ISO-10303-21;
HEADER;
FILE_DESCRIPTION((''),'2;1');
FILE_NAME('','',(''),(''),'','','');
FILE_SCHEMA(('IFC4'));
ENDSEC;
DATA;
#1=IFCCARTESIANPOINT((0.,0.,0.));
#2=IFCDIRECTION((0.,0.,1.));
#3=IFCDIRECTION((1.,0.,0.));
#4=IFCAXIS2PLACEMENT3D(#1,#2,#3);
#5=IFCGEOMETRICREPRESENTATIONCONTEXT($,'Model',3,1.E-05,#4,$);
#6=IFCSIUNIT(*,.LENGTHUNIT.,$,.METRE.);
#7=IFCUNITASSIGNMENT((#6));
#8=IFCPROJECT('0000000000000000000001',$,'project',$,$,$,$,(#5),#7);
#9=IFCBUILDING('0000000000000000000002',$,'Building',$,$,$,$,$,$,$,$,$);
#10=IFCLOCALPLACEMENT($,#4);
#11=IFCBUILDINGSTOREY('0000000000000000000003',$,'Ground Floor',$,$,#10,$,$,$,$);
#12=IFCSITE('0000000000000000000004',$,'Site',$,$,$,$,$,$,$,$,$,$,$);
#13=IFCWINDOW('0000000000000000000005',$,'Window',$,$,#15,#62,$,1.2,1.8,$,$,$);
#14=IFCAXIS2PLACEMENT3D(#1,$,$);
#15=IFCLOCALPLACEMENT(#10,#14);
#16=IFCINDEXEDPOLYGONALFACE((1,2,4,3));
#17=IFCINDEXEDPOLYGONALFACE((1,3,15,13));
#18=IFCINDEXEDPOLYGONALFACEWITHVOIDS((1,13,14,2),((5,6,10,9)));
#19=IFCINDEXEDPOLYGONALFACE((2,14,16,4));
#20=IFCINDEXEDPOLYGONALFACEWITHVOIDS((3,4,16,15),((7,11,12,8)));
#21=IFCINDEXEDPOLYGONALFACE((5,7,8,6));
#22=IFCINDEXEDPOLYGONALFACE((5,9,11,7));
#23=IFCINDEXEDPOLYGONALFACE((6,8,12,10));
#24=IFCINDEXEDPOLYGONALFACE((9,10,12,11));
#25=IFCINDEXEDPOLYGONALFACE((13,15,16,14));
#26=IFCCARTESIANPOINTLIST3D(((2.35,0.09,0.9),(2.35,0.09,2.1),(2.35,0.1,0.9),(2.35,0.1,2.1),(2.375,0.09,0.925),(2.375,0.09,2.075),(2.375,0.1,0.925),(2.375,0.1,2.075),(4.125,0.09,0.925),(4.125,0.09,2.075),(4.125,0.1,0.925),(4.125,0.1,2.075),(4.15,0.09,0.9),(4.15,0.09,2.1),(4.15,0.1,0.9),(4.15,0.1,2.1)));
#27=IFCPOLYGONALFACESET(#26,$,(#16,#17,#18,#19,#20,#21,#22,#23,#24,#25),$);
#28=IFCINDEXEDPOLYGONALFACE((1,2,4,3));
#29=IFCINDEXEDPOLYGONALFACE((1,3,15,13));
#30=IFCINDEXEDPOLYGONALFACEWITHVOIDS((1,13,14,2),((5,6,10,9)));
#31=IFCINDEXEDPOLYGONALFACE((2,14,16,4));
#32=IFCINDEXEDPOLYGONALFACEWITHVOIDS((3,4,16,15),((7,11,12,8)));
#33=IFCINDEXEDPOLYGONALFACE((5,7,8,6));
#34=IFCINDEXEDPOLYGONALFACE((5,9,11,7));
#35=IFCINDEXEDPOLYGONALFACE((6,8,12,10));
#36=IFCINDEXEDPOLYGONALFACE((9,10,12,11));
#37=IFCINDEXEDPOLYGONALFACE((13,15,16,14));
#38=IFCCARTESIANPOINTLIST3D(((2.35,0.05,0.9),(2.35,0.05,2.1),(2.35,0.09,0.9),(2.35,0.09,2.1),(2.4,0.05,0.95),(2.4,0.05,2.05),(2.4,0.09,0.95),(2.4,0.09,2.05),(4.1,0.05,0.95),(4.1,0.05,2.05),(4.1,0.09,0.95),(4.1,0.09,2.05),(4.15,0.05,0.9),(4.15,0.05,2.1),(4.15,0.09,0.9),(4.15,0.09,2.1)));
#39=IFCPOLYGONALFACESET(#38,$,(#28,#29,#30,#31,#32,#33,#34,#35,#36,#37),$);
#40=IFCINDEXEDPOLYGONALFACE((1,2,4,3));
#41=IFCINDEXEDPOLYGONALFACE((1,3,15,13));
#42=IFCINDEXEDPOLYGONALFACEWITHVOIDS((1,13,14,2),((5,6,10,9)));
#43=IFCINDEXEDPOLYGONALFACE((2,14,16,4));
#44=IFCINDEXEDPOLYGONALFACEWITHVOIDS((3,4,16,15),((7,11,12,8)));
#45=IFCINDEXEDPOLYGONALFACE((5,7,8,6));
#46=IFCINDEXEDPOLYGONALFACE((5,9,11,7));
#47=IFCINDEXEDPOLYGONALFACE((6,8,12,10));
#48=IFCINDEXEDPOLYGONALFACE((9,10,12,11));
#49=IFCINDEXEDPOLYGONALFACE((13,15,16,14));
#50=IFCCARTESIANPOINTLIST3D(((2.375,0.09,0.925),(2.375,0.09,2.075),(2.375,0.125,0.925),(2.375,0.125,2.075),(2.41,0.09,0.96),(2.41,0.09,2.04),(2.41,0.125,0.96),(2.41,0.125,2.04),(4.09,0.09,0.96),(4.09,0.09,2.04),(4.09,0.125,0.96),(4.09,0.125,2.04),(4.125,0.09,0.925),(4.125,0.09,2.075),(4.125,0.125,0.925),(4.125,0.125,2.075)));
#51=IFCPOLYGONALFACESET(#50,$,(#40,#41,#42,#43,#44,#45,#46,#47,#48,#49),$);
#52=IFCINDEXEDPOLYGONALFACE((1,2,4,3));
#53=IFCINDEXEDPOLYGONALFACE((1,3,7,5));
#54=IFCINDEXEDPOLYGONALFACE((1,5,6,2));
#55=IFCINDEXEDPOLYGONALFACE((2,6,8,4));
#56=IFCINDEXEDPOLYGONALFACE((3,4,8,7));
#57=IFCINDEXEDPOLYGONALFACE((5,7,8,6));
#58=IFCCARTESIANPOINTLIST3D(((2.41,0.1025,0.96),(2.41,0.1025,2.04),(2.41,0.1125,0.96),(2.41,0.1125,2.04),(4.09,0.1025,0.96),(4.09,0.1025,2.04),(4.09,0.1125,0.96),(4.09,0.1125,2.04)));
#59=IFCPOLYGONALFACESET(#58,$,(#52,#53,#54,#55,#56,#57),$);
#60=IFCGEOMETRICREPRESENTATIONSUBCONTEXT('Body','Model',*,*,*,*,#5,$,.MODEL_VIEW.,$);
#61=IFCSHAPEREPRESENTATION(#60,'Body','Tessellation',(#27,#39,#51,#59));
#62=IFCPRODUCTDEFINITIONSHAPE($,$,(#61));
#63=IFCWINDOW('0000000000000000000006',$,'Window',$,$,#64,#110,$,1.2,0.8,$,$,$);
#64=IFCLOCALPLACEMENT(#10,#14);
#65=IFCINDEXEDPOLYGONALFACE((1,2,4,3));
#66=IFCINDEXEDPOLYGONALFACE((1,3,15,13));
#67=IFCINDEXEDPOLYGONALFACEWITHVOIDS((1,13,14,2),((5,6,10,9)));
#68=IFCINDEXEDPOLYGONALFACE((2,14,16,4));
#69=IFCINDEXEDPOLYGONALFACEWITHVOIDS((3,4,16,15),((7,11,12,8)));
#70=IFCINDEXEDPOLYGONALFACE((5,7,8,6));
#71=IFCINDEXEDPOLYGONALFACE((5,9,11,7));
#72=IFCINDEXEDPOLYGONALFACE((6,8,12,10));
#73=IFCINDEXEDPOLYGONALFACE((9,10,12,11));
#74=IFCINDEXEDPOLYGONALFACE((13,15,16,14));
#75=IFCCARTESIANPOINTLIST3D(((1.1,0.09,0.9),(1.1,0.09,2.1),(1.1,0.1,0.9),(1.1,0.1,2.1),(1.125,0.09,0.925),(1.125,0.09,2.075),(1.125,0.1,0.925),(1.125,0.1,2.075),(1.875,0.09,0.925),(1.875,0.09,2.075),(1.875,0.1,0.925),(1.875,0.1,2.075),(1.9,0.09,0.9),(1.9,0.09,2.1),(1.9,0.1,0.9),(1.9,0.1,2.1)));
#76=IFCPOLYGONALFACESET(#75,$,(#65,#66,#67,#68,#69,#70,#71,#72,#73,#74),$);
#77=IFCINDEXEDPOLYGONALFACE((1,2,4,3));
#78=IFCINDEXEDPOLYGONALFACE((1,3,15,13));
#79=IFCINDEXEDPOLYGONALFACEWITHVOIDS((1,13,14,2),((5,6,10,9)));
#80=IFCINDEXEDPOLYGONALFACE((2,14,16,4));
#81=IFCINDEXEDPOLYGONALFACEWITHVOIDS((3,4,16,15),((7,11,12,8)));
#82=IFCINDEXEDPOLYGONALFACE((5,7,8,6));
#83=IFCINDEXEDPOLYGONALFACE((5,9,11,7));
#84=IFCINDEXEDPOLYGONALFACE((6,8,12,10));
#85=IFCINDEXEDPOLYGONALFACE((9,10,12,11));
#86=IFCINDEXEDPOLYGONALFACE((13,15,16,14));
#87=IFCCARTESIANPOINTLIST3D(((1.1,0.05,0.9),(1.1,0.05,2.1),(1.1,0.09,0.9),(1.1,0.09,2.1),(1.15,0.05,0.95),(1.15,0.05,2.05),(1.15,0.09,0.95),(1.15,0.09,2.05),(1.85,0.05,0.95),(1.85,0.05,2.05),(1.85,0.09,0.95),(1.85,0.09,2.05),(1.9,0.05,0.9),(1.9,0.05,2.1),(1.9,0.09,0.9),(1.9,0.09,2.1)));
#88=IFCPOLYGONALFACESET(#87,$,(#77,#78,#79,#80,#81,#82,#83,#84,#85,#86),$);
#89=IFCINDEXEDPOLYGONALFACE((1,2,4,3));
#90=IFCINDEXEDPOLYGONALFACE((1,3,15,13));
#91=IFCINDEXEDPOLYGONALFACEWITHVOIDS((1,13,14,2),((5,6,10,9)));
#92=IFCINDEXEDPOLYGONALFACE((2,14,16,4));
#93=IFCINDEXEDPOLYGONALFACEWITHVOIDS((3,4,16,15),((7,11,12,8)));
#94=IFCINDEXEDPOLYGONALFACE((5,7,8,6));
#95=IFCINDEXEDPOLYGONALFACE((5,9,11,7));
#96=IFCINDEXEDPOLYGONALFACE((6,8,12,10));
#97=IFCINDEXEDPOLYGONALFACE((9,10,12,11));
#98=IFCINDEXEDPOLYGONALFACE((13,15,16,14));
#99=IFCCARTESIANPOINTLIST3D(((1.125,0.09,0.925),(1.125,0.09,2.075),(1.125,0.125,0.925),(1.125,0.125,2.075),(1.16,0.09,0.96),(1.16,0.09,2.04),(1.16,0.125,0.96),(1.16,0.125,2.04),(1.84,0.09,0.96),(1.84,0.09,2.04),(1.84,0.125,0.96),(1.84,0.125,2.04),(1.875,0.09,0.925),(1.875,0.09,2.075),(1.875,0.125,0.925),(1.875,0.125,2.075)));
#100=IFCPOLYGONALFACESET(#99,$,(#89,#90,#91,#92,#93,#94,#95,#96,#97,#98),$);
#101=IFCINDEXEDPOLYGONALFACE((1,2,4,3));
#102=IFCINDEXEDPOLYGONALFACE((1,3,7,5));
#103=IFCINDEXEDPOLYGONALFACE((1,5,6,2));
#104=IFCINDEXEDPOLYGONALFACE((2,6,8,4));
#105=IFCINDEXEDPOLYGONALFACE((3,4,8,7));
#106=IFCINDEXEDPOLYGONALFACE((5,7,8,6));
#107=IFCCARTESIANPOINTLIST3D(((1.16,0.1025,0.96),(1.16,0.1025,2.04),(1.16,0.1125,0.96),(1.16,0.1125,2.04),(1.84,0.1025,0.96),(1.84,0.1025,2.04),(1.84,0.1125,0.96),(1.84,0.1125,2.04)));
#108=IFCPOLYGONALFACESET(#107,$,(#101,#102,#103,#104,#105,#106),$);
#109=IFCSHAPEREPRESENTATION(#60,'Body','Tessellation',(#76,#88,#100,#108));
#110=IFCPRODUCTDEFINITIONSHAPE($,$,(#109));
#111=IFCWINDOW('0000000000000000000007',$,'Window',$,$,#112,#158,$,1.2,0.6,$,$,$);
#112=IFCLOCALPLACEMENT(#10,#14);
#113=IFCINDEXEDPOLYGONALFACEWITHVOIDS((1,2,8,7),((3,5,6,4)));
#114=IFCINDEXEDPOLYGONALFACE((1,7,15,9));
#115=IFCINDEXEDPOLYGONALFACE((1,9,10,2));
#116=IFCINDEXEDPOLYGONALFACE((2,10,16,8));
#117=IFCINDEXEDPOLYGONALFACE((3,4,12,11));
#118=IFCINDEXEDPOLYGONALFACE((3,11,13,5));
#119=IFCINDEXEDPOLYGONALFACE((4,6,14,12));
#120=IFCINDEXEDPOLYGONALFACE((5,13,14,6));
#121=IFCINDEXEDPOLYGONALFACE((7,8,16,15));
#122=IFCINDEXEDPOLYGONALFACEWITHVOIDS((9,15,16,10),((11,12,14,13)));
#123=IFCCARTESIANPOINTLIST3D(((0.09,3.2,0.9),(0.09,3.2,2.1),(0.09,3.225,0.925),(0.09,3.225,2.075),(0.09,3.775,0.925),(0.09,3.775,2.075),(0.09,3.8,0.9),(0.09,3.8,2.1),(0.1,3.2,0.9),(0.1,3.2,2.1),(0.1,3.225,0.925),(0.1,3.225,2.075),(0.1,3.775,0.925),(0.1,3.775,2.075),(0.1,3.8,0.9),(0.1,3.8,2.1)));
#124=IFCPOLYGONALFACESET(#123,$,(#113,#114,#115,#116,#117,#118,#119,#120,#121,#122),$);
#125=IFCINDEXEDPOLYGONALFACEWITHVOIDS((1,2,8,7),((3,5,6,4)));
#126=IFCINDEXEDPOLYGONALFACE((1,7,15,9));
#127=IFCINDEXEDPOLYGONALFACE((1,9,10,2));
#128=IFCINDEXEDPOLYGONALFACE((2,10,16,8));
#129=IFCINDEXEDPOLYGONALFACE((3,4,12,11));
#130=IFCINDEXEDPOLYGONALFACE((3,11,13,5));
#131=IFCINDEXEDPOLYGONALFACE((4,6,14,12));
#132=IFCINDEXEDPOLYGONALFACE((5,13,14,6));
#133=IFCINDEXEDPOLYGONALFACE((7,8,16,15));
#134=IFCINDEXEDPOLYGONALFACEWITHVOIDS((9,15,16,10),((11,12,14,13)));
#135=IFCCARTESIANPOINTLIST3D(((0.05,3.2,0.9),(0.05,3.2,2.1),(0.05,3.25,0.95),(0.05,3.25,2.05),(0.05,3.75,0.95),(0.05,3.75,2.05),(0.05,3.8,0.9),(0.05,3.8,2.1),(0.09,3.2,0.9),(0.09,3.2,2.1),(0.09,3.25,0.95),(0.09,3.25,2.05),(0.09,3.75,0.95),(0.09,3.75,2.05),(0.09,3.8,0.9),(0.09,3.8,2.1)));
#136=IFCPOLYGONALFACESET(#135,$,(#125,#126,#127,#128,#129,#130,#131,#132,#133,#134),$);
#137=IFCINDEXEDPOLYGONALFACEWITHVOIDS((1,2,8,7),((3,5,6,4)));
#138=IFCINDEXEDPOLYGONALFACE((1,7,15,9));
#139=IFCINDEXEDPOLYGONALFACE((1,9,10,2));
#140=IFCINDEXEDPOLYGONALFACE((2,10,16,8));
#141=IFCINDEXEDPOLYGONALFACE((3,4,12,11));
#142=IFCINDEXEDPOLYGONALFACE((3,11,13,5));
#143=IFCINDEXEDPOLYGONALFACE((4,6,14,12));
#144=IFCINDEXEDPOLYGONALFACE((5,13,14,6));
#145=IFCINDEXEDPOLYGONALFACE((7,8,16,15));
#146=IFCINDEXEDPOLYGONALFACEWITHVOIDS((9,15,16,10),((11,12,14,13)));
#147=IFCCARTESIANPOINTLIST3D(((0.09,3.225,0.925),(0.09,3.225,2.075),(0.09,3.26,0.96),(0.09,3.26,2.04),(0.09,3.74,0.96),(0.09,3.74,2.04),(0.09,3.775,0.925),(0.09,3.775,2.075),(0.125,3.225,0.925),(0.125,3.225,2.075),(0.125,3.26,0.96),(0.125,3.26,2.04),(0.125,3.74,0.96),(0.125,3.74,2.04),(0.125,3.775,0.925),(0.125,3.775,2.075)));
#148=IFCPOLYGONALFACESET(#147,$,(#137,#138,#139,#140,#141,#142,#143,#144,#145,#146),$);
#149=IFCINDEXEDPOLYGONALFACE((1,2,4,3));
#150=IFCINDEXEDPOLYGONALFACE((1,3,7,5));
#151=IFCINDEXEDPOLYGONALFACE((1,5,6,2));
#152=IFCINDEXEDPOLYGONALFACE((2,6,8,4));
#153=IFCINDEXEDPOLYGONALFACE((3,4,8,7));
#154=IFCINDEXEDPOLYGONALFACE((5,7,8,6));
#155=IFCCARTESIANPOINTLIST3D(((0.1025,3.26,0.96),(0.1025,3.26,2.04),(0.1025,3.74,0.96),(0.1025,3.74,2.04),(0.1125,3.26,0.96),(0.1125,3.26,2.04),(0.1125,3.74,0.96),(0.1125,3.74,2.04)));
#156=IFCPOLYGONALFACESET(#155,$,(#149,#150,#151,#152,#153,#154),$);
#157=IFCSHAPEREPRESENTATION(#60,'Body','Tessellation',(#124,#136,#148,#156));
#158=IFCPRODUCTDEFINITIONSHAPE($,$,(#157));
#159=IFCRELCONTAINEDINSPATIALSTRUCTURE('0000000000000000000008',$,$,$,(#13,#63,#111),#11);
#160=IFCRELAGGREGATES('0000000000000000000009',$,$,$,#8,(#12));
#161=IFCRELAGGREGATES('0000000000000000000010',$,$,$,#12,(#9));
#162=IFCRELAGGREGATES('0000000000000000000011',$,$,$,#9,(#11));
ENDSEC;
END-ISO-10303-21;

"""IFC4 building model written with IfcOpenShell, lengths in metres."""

from ifc_helpers import new_model, si_unit, frame, origin_with_axes, place, context, subcontext, project, spatial, line, indexed_curve, outline, extrude, element, save


model = new_model("IFC4")

# Units and contexts
model_context = context("Model", 3, precision=1e-05, world=origin_with_axes())
body_context = subcontext(model_context, "Body", "Model", "MODEL_VIEW")
ifc_project = project(units=[si_unit("LENGTHUNIT", "METRE")], contexts=[model_context])

# Site, building, storey
site = spatial("IfcSite", under=ifc_project, Name="Site")
building = spatial("IfcBuilding", under=site, Name="Building")
storey_placement = place(None, origin_with_axes())
storey = spatial("IfcBuildingStorey", under=building, at=storey_placement, Name="Ground Floor")

# Windows
window_1_placement = place(storey_placement, frame((2.35, 0.0, 0.9), z_axis=(0.0, 0.0, 1.0), x_axis=(1.0, 0.0, 0.0)))
element("IfcWindow", 1, at=window_1_placement, inside=storey, Name="Window", OverallHeight=1.2, OverallWidth=1.8, context=body_context, shape_type="SweptSolid", body=[
    extrude(outline(indexed_curve([(0.0, 0.0), (1.8, 0.0), (1.8, 1.2), (0.0, 1.2)], segments=[line(1, 2, 3, 4, 1)]), holes=[indexed_curve([(0.025, 0.025), (1.775, 0.025), (1.775, 1.175), (0.025, 1.175)], segments=[line(1, 2, 3, 4, 1)])]), frame((0.0, 0.09, 0.0), z_axis=(0.0, -1.0, 0.0), x_axis=(1.0, 0.0, 0.0)), (0.0, 0.0, -1.0), 0.01),
    extrude(outline(indexed_curve([(0.0, 0.0), (1.8, 0.0), (1.8, 1.2), (0.0, 1.2)], segments=[line(1, 2, 3, 4, 1)]), holes=[indexed_curve([(0.05, 0.05), (1.75, 0.05), (1.75, 1.15), (0.05, 1.15)], segments=[line(1, 2, 3, 4, 1)])]), frame((0.0, 0.05, 0.0), z_axis=(0.0, -1.0, 0.0), x_axis=(1.0, 0.0, 0.0)), (0.0, 0.0, -1.0), 0.04),
    extrude(outline(indexed_curve([(0.0, 0.0), (1.75, 0.0), (1.75, 1.15), (0.0, 1.15)], segments=[line(1, 2, 3, 4, 1)]), holes=[indexed_curve([(0.035, 0.035), (1.715, 0.035), (1.715, 1.115), (0.035, 1.115)], segments=[line(1, 2, 3, 4, 1)])]), frame((0.025, 0.09, 0.025), z_axis=(0.0, -1.0, 0.0), x_axis=(1.0, 0.0, 0.0)), (0.0, 0.0, -1.0), 0.035),
    extrude(outline(indexed_curve([(0.035, 0.035), (1.715, 0.035), (1.715, 1.115), (0.035, 1.115)], segments=[line(1, 2, 3, 4, 1)])), frame((0.025, 0.1025, 0.025), z_axis=(0.0, -1.0, 0.0), x_axis=(1.0, 0.0, 0.0)), (0.0, 0.0, -1.0), 0.01),
])
window_2_placement = place(storey_placement, frame((1.1, 0.0, 0.9), z_axis=(0.0, 0.0, 1.0), x_axis=(1.0, 0.0, 0.0)))
element("IfcWindow", 2, at=window_2_placement, inside=storey, Name="Window", OverallHeight=1.2, OverallWidth=0.8, context=body_context, shape_type="SweptSolid", body=[
    extrude(outline(indexed_curve([(0.0, 0.0), (0.8, 0.0), (0.8, 1.2), (0.0, 1.2)], segments=[line(1, 2, 3, 4, 1)]), holes=[indexed_curve([(0.025, 0.025), (0.775, 0.025), (0.775, 1.175), (0.025, 1.175)], segments=[line(1, 2, 3, 4, 1)])]), frame((0.0, 0.09, 0.0), z_axis=(0.0, -1.0, 0.0), x_axis=(1.0, 0.0, 0.0)), (0.0, 0.0, -1.0), 0.01),
    extrude(outline(indexed_curve([(0.0, 0.0), (0.8, 0.0), (0.8, 1.2), (0.0, 1.2)], segments=[line(1, 2, 3, 4, 1)]), holes=[indexed_curve([(0.05, 0.05), (0.75, 0.05), (0.75, 1.15), (0.05, 1.15)], segments=[line(1, 2, 3, 4, 1)])]), frame((0.0, 0.05, 0.0), z_axis=(0.0, -1.0, 0.0), x_axis=(1.0, 0.0, 0.0)), (0.0, 0.0, -1.0), 0.04),
    extrude(outline(indexed_curve([(0.0, 0.0), (0.75, 0.0), (0.75, 1.15), (0.0, 1.15)], segments=[line(1, 2, 3, 4, 1)]), holes=[indexed_curve([(0.035, 0.035), (0.715, 0.035), (0.715, 1.115), (0.035, 1.115)], segments=[line(1, 2, 3, 4, 1)])]), frame((0.025, 0.09, 0.025), z_axis=(0.0, -1.0, 0.0), x_axis=(1.0, 0.0, 0.0)), (0.0, 0.0, -1.0), 0.035),
    extrude(outline(indexed_curve([(0.035, 0.035), (0.715, 0.035), (0.715, 1.115), (0.035, 1.115)], segments=[line(1, 2, 3, 4, 1)])), frame((0.025, 0.1025, 0.025), z_axis=(0.0, -1.0, 0.0), x_axis=(1.0, 0.0, 0.0)), (0.0, 0.0, -1.0), 0.01),
])
window_3_placement = place(storey_placement, frame((0.0, 3.8, 0.9), z_axis=(0.0, 0.0, 1.0), x_axis=(0.0, -1.0, 0.0)))
element("IfcWindow", 3, at=window_3_placement, inside=storey, Name="Window", OverallHeight=1.2, OverallWidth=0.6, context=body_context, shape_type="SweptSolid", body=[
    extrude(outline(indexed_curve([(0.0, 0.0), (0.6, 0.0), (0.6, 1.2), (0.0, 1.2)], segments=[line(1, 2, 3, 4, 1)]), holes=[indexed_curve([(0.025, 0.025), (0.575, 0.025), (0.575, 1.175), (0.025, 1.175)], segments=[line(1, 2, 3, 4, 1)])]), frame((0.0, 0.09, 0.0), z_axis=(0.0, -1.0, 0.0), x_axis=(1.0, 0.0, 0.0)), (0.0, 0.0, -1.0), 0.01),
    extrude(outline(indexed_curve([(0.0, 0.0), (0.6, 0.0), (0.6, 1.2), (0.0, 1.2)], segments=[line(1, 2, 3, 4, 1)]), holes=[indexed_curve([(0.05, 0.05), (0.55, 0.05), (0.55, 1.15), (0.05, 1.15)], segments=[line(1, 2, 3, 4, 1)])]), frame((0.0, 0.05, 0.0), z_axis=(0.0, -1.0, 0.0), x_axis=(1.0, 0.0, 0.0)), (0.0, 0.0, -1.0), 0.04),
    extrude(outline(indexed_curve([(0.0, 0.0), (0.55, 0.0), (0.55, 1.15), (0.0, 1.15)], segments=[line(1, 2, 3, 4, 1)]), holes=[indexed_curve([(0.035, 0.035), (0.515, 0.035), (0.515, 1.115), (0.035, 1.115)], segments=[line(1, 2, 3, 4, 1)])]), frame((0.025, 0.09, 0.025), z_axis=(0.0, -1.0, 0.0), x_axis=(1.0, 0.0, 0.0)), (0.0, 0.0, -1.0), 0.035),
    extrude(outline(indexed_curve([(0.035, 0.035), (0.515, 0.035), (0.515, 1.115), (0.035, 1.115)], segments=[line(1, 2, 3, 4, 1)])), frame((0.025, 0.1025, 0.025), z_axis=(0.0, -1.0, 0.0), x_axis=(1.0, 0.0, 0.0)), (0.0, 0.0, -1.0), 0.01),
])

save(model, "model.ifc")
